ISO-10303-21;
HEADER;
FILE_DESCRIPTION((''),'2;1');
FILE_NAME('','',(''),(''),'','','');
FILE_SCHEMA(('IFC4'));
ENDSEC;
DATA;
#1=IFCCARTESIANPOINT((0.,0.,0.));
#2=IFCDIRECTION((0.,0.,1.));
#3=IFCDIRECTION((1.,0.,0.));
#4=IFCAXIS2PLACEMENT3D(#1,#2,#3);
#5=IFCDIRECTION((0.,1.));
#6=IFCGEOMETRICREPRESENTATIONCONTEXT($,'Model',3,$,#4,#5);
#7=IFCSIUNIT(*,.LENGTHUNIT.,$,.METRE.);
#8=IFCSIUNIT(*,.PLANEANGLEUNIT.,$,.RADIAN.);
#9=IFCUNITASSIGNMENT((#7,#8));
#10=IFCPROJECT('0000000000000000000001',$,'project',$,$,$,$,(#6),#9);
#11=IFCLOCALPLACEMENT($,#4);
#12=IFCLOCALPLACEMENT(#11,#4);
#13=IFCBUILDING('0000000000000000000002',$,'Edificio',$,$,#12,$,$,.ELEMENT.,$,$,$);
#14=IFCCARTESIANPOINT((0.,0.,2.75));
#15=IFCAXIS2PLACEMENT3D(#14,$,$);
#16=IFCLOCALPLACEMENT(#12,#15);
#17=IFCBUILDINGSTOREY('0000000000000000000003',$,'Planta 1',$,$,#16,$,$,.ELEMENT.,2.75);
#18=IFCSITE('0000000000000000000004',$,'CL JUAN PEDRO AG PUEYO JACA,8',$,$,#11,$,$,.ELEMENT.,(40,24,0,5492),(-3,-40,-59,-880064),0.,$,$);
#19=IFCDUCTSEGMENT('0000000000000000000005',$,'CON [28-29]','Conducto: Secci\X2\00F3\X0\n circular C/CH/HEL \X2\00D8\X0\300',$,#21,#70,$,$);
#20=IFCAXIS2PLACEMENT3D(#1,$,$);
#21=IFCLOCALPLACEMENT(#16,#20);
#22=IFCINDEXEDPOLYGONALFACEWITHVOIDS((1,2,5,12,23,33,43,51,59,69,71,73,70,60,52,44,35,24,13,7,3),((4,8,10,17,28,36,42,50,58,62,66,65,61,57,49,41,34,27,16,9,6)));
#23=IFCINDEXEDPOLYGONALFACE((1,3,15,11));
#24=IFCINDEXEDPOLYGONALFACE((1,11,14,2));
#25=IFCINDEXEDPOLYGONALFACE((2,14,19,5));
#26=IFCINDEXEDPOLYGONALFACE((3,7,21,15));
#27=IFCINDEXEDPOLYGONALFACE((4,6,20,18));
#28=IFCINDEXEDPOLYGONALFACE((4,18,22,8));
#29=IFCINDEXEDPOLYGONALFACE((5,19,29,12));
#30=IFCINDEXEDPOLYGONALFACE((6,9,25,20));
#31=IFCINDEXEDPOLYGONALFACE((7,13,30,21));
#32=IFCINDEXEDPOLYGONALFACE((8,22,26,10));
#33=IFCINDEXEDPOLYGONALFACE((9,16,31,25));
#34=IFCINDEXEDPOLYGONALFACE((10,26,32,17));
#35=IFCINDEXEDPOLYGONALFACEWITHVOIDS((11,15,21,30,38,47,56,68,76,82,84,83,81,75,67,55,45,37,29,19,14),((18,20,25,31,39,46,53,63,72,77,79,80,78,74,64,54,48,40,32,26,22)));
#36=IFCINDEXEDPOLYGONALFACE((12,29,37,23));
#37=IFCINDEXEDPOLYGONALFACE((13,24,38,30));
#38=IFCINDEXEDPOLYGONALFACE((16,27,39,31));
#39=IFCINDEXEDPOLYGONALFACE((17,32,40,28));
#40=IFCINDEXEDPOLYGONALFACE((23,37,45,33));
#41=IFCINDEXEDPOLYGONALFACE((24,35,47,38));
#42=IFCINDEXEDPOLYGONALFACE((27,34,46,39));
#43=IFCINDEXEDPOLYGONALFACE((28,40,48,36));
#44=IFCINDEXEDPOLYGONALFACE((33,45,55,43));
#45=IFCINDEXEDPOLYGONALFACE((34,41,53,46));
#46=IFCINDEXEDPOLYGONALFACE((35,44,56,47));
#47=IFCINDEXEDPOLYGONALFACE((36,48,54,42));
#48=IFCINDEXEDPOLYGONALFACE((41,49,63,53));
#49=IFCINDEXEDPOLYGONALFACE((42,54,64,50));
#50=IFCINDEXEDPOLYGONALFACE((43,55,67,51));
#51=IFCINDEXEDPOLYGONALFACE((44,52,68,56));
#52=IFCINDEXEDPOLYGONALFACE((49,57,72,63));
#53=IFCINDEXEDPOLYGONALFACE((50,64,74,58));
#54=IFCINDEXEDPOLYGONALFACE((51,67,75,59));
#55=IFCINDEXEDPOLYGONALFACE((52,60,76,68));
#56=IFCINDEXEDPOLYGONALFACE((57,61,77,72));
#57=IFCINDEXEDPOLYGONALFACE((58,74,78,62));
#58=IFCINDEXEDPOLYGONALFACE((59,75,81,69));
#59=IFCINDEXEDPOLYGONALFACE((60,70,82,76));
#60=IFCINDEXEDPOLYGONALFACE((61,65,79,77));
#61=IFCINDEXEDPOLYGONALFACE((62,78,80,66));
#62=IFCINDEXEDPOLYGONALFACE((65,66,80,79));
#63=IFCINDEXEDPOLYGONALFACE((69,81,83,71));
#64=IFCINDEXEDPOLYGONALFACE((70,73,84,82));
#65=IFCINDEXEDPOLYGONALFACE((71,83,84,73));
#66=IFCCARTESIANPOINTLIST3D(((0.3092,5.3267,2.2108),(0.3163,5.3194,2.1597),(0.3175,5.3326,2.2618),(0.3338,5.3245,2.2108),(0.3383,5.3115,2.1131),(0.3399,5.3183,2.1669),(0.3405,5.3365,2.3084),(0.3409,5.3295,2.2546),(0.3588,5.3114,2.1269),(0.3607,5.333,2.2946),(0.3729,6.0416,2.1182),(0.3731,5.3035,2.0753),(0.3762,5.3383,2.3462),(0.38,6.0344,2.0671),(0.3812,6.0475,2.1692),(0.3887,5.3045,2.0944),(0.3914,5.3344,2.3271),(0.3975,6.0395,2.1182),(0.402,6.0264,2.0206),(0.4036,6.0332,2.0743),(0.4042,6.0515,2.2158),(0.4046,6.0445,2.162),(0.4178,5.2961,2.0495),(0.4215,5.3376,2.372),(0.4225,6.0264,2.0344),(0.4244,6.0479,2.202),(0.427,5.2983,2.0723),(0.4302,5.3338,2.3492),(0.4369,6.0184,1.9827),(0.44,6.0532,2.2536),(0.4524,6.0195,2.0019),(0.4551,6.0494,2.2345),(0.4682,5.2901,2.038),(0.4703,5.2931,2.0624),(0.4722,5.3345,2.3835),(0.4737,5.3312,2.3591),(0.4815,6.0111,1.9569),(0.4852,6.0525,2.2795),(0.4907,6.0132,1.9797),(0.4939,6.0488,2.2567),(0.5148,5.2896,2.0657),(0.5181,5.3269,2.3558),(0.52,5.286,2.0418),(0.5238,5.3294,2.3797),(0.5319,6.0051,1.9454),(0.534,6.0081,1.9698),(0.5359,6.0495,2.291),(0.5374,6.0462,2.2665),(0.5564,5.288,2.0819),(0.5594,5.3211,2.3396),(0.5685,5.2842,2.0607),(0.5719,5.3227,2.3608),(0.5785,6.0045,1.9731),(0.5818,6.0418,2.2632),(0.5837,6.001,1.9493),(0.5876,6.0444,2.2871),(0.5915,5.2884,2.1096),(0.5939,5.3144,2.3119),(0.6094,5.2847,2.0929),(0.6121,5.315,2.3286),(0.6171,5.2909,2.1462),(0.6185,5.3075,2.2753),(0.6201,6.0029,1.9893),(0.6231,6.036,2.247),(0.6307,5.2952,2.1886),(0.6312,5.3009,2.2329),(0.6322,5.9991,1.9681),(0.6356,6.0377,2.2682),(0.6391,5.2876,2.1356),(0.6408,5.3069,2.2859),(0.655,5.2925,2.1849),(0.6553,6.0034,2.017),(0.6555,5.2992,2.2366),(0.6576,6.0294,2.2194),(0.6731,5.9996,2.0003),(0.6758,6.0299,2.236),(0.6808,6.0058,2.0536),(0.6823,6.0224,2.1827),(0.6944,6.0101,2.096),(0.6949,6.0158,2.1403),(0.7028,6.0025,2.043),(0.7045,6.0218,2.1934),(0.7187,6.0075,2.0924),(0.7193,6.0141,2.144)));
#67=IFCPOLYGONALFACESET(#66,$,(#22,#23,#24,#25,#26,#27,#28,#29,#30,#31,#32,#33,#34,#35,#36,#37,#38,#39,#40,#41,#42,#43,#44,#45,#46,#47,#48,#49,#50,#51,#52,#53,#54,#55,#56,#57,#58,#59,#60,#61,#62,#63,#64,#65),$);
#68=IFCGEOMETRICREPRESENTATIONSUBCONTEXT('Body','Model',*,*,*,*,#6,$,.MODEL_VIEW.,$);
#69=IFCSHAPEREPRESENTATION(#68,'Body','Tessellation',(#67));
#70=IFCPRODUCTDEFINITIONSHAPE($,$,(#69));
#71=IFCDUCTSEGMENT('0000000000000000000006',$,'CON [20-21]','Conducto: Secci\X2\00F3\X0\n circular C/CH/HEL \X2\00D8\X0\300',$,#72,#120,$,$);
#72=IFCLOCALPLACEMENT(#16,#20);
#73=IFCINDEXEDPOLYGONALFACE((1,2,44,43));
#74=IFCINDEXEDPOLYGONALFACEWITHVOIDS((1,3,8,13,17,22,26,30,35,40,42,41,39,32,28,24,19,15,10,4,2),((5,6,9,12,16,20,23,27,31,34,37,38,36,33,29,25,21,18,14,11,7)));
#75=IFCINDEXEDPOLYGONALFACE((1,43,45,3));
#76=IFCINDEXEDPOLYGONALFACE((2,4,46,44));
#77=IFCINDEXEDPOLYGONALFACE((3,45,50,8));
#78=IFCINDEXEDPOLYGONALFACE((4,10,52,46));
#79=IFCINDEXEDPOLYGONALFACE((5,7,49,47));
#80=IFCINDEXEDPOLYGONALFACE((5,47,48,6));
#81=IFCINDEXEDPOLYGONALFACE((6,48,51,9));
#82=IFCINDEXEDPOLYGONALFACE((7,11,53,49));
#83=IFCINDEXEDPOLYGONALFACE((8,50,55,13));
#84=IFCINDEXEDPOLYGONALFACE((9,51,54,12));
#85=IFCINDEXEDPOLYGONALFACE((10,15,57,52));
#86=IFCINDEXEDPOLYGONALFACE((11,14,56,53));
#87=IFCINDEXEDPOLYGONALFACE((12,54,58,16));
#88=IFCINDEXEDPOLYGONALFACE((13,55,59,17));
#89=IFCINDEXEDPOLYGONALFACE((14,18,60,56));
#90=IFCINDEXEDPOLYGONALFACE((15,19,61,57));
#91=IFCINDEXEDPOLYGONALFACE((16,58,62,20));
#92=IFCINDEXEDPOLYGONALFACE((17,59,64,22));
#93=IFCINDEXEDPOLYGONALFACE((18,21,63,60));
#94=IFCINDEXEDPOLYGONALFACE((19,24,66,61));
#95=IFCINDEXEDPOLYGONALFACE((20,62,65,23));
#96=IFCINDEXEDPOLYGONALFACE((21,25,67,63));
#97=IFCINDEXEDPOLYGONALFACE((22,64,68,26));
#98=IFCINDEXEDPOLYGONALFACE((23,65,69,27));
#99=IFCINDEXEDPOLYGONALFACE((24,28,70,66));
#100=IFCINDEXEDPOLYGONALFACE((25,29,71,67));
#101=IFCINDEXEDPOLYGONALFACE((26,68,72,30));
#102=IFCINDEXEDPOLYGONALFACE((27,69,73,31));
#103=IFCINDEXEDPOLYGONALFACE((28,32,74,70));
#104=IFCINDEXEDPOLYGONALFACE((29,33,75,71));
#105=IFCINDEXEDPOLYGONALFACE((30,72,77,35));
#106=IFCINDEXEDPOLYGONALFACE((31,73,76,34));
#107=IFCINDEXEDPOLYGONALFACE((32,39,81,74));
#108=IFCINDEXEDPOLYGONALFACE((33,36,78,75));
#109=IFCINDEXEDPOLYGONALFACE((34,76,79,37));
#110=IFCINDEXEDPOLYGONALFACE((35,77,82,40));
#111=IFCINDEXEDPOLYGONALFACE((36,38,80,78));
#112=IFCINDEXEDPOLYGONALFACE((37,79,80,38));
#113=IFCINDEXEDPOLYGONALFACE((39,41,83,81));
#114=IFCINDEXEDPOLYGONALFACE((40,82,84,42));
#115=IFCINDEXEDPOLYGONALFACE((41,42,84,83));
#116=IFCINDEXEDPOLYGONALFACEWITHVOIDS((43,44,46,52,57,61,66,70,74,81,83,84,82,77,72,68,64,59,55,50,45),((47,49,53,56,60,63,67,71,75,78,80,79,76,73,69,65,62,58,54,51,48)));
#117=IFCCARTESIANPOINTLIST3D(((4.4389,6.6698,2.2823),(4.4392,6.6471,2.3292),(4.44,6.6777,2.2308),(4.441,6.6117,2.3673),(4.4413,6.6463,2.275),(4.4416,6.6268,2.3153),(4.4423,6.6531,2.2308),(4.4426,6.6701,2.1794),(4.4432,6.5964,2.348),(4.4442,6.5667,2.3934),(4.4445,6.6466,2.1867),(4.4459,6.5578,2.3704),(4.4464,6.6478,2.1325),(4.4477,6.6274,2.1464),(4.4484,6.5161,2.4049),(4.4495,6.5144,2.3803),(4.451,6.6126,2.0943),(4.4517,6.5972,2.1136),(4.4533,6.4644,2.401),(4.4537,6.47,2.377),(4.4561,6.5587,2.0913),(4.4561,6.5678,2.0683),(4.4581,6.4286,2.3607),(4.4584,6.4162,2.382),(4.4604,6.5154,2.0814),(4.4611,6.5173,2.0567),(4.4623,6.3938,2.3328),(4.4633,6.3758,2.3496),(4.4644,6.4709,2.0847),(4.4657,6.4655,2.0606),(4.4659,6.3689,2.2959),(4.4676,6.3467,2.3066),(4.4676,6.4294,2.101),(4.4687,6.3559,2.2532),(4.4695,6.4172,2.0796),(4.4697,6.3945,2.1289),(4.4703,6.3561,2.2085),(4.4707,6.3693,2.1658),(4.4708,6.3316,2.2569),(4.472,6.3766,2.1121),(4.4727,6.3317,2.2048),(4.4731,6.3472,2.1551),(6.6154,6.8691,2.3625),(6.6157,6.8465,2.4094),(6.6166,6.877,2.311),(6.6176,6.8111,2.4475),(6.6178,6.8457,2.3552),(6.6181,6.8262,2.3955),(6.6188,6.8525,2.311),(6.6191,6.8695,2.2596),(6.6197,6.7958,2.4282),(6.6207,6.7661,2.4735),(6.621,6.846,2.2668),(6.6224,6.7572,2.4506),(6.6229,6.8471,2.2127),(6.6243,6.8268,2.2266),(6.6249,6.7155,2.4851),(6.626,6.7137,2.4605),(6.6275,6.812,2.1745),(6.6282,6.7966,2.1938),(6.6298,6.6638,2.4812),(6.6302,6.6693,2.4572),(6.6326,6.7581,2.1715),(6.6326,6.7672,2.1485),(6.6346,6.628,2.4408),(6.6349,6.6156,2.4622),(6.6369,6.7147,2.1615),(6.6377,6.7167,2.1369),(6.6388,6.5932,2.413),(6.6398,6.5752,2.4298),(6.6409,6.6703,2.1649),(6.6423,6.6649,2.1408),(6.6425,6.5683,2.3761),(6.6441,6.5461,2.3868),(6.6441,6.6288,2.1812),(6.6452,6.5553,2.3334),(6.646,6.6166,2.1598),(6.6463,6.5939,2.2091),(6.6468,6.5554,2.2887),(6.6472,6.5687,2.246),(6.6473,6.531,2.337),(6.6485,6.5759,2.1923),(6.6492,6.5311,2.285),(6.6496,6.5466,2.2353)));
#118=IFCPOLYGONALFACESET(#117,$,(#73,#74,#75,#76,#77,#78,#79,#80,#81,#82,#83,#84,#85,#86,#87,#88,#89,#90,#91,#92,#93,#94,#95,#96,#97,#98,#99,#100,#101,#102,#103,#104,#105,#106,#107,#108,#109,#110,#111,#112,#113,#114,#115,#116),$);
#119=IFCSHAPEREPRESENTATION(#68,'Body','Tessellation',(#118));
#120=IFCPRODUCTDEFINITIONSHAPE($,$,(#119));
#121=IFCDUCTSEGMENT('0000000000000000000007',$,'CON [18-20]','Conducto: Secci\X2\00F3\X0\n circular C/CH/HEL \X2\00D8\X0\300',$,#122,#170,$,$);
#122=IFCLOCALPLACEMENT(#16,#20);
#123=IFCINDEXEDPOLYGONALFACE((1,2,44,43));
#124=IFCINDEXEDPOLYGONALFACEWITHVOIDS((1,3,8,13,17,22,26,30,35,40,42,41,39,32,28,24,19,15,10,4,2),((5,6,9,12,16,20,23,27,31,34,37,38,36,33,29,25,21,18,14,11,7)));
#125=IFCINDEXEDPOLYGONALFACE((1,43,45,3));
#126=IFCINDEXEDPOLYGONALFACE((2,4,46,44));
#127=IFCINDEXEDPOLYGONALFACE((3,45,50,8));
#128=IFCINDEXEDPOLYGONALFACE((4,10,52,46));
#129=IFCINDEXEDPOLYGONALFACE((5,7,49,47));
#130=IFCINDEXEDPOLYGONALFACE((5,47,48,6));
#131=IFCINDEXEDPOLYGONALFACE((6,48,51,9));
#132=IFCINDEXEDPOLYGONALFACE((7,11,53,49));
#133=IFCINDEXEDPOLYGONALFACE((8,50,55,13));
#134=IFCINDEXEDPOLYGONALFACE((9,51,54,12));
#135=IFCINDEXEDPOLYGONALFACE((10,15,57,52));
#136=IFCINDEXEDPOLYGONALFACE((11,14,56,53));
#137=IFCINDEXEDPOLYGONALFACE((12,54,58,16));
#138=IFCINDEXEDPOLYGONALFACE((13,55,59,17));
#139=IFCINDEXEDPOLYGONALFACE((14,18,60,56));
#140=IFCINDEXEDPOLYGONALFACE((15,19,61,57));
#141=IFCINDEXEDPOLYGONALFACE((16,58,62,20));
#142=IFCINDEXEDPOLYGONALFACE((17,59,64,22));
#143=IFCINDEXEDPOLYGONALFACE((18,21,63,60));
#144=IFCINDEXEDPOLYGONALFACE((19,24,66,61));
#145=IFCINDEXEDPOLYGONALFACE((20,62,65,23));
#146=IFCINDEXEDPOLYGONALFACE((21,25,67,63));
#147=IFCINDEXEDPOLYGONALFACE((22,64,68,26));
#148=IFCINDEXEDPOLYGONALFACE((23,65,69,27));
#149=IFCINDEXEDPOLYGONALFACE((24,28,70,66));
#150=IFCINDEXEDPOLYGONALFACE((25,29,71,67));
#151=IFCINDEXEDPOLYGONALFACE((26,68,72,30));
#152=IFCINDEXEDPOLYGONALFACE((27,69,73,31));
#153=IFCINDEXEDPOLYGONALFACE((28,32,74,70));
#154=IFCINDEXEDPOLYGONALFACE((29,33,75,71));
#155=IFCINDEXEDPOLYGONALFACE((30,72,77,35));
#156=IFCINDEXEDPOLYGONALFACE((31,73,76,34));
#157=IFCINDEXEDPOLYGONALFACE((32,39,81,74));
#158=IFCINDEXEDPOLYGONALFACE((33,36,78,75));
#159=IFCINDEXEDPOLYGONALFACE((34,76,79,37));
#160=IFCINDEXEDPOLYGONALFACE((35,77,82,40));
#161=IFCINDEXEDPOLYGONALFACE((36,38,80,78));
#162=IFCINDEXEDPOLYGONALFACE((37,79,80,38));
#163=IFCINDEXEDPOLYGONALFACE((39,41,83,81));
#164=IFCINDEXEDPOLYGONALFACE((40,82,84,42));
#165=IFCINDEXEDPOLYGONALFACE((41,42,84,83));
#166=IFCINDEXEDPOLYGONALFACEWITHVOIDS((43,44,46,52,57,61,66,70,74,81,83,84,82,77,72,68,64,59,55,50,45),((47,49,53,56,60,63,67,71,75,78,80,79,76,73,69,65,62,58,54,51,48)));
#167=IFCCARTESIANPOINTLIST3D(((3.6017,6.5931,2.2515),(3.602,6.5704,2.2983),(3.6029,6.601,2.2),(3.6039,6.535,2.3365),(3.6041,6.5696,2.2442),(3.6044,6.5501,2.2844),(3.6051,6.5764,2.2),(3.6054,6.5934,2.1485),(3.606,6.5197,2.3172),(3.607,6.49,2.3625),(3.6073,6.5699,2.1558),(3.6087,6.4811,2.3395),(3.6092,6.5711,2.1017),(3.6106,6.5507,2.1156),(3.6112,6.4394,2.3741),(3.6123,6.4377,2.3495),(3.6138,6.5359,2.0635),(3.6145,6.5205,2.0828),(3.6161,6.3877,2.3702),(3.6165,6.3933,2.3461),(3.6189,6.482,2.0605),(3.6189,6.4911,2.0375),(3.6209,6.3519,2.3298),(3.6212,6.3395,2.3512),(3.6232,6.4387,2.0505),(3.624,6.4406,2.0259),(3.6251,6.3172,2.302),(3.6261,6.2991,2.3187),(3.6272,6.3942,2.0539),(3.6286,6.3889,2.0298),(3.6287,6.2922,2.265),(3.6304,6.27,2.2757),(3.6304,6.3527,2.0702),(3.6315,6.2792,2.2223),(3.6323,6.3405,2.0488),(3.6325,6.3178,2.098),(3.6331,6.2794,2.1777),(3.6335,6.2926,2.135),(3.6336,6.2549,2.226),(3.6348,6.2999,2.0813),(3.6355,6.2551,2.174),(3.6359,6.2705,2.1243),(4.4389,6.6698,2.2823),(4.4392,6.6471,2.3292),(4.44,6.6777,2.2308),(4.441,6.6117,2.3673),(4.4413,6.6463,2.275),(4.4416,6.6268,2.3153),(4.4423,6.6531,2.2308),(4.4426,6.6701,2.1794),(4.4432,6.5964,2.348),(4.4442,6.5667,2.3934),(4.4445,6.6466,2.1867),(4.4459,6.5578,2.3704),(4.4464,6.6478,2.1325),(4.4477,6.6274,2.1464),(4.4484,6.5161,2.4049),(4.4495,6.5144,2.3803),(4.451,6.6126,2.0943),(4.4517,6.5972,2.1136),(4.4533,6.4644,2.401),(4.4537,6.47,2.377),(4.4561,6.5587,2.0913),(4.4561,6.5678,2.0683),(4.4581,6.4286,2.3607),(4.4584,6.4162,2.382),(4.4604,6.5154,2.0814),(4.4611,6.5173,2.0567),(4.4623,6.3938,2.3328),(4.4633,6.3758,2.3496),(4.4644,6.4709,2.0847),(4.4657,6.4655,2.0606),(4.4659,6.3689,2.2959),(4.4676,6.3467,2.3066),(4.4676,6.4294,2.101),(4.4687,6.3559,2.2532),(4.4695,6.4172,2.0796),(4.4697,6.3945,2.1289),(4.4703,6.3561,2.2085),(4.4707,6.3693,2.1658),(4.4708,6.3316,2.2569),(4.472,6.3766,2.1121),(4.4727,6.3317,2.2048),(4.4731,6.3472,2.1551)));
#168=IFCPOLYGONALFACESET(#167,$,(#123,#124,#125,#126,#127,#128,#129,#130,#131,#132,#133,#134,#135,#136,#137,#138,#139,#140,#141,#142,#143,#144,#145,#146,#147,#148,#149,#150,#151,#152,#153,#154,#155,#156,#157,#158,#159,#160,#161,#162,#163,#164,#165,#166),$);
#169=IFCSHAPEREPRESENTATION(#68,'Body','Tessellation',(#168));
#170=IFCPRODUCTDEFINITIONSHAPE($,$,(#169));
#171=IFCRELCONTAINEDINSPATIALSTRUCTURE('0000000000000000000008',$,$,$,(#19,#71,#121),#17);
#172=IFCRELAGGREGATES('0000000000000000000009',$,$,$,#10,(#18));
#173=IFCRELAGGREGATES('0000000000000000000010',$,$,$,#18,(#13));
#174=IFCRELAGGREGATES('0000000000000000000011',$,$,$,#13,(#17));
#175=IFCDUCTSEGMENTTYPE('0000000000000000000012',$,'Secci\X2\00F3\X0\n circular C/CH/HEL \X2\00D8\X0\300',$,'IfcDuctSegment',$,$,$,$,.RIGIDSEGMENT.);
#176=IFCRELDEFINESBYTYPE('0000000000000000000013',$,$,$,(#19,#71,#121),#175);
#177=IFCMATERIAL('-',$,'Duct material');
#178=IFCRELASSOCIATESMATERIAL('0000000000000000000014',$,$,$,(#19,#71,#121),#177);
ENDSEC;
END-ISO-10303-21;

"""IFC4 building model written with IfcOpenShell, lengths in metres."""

from ifc_helpers import new_model, si_unit, direction, frame, origin_with_axes, origin_2d_with_axis, place, context, subcontext, project, spatial, hollow_circle, extrude, material, type_object, element, save


model = new_model("IFC4")

# Units and contexts
model_context = context("Model", 3, world=origin_with_axes(), true_north=direction((0.0, 1.0)))
body_context = subcontext(model_context, "Body", "Model", "MODEL_VIEW")
ifc_project = project(units=[si_unit("LENGTHUNIT", "METRE"), si_unit("PLANEANGLEUNIT", "RADIAN")], contexts=[model_context])

# Site, building, storey
site_placement = place(None, origin_with_axes())
site = spatial("IfcSite", under=ifc_project, at=site_placement, Name="CL JUAN PEDRO AG PUEYO JACA,8", CompositionType="ELEMENT", RefLatitude=(40, 24, 0, 5492), RefLongitude=(-3, -40, -59, -880064), RefElevation=0.0)
building_placement = place(site_placement, origin_with_axes())
building = spatial("IfcBuilding", under=site, at=building_placement, Name="Edificio", CompositionType="ELEMENT")
storey_placement = place(building_placement, frame((0.0, 0.0, 2.75)))
storey = spatial("IfcBuildingStorey", under=building, at=storey_placement, Name="Planta 1", CompositionType="ELEMENT", Elevation=2.75)

# Shared definitions
ifc_material_1 = material(Name="-", Category="Duct material")

# Duct segments
duct_segment_type_1 = type_object("IfcDuctSegmentType", Name="Sección circular C/CH/HEL Ø300", ApplicableOccurrence="IfcDuctSegment", PredefinedType="RIGIDSEGMENT")
duct_segment_1_placement = place(storey_placement, frame((0.0, 0.0, -2.75), z_axis=(0.0, 0.0, 1.0), x_axis=(1.0, 0.0, 0.0)))
element("IfcDuctSegment", 1, at=duct_segment_1_placement, inside=storey, type_object=duct_segment_type_1, material=ifc_material_1, Name="CON [28-29]", Description="Conducto: Sección circular C/CH/HEL Ø300", context=body_context, shape_type="SweptSolid", body=[
    extrude(hollow_circle(Radius=0.1747, WallThickness=0.0247, at=origin_2d_with_axis()), frame((0.4832, 5.3112, 4.9608), z_axis=(0.088041, 0.98787, -0.127911), x_axis=(-0.996052, 0.08877, 0.0)), (0.0, 0.0, 1.0), 0.7237),
])
duct_segment_2_placement = place(storey_placement, frame((0.0, 0.0, -2.75), z_axis=(0.0, 0.0, 1.0), x_axis=(1.0, 0.0, 0.0)))
element("IfcDuctSegment", 2, at=duct_segment_2_placement, inside=storey, type_object=duct_segment_type_1, material=ifc_material_1, Name="CON [20-21]", Description="Conducto: Sección circular C/CH/HEL Ø300", context=body_context, shape_type="SweptSolid", body=[
    extrude(hollow_circle(Radius=0.1747, WallThickness=0.0247, at=origin_2d_with_axis()), frame((4.456, 6.5037, 4.9808), z_axis=(0.995161, 0.091165, 0.036663), x_axis=(-0.091226, 0.99583, 0.0)), (0.0, 0.0, 1.0), 2.1871),
])
duct_segment_3_placement = place(storey_placement, frame((0.0, 0.0, -2.75), z_axis=(0.0, 0.0, 1.0), x_axis=(1.0, 0.0, 0.0)))
element("IfcDuctSegment", 3, at=duct_segment_3_placement, inside=storey, type_object=duct_segment_type_1, material=ifc_material_1, Name="CON [18-20]", Description="Conducto: Sección circular C/CH/HEL Ø300", context=body_context, shape_type="SweptSolid", body=[
    extrude(hollow_circle(Radius=0.1747, WallThickness=0.0247, at=origin_2d_with_axis()), frame((3.6188, 6.427, 4.95), z_axis=(0.995161, 0.091165, 0.036663), x_axis=(-0.091226, 0.99583, 0.0)), (0.0, 0.0, 1.0), 0.8412),
])

save(model, "model.ifc")
